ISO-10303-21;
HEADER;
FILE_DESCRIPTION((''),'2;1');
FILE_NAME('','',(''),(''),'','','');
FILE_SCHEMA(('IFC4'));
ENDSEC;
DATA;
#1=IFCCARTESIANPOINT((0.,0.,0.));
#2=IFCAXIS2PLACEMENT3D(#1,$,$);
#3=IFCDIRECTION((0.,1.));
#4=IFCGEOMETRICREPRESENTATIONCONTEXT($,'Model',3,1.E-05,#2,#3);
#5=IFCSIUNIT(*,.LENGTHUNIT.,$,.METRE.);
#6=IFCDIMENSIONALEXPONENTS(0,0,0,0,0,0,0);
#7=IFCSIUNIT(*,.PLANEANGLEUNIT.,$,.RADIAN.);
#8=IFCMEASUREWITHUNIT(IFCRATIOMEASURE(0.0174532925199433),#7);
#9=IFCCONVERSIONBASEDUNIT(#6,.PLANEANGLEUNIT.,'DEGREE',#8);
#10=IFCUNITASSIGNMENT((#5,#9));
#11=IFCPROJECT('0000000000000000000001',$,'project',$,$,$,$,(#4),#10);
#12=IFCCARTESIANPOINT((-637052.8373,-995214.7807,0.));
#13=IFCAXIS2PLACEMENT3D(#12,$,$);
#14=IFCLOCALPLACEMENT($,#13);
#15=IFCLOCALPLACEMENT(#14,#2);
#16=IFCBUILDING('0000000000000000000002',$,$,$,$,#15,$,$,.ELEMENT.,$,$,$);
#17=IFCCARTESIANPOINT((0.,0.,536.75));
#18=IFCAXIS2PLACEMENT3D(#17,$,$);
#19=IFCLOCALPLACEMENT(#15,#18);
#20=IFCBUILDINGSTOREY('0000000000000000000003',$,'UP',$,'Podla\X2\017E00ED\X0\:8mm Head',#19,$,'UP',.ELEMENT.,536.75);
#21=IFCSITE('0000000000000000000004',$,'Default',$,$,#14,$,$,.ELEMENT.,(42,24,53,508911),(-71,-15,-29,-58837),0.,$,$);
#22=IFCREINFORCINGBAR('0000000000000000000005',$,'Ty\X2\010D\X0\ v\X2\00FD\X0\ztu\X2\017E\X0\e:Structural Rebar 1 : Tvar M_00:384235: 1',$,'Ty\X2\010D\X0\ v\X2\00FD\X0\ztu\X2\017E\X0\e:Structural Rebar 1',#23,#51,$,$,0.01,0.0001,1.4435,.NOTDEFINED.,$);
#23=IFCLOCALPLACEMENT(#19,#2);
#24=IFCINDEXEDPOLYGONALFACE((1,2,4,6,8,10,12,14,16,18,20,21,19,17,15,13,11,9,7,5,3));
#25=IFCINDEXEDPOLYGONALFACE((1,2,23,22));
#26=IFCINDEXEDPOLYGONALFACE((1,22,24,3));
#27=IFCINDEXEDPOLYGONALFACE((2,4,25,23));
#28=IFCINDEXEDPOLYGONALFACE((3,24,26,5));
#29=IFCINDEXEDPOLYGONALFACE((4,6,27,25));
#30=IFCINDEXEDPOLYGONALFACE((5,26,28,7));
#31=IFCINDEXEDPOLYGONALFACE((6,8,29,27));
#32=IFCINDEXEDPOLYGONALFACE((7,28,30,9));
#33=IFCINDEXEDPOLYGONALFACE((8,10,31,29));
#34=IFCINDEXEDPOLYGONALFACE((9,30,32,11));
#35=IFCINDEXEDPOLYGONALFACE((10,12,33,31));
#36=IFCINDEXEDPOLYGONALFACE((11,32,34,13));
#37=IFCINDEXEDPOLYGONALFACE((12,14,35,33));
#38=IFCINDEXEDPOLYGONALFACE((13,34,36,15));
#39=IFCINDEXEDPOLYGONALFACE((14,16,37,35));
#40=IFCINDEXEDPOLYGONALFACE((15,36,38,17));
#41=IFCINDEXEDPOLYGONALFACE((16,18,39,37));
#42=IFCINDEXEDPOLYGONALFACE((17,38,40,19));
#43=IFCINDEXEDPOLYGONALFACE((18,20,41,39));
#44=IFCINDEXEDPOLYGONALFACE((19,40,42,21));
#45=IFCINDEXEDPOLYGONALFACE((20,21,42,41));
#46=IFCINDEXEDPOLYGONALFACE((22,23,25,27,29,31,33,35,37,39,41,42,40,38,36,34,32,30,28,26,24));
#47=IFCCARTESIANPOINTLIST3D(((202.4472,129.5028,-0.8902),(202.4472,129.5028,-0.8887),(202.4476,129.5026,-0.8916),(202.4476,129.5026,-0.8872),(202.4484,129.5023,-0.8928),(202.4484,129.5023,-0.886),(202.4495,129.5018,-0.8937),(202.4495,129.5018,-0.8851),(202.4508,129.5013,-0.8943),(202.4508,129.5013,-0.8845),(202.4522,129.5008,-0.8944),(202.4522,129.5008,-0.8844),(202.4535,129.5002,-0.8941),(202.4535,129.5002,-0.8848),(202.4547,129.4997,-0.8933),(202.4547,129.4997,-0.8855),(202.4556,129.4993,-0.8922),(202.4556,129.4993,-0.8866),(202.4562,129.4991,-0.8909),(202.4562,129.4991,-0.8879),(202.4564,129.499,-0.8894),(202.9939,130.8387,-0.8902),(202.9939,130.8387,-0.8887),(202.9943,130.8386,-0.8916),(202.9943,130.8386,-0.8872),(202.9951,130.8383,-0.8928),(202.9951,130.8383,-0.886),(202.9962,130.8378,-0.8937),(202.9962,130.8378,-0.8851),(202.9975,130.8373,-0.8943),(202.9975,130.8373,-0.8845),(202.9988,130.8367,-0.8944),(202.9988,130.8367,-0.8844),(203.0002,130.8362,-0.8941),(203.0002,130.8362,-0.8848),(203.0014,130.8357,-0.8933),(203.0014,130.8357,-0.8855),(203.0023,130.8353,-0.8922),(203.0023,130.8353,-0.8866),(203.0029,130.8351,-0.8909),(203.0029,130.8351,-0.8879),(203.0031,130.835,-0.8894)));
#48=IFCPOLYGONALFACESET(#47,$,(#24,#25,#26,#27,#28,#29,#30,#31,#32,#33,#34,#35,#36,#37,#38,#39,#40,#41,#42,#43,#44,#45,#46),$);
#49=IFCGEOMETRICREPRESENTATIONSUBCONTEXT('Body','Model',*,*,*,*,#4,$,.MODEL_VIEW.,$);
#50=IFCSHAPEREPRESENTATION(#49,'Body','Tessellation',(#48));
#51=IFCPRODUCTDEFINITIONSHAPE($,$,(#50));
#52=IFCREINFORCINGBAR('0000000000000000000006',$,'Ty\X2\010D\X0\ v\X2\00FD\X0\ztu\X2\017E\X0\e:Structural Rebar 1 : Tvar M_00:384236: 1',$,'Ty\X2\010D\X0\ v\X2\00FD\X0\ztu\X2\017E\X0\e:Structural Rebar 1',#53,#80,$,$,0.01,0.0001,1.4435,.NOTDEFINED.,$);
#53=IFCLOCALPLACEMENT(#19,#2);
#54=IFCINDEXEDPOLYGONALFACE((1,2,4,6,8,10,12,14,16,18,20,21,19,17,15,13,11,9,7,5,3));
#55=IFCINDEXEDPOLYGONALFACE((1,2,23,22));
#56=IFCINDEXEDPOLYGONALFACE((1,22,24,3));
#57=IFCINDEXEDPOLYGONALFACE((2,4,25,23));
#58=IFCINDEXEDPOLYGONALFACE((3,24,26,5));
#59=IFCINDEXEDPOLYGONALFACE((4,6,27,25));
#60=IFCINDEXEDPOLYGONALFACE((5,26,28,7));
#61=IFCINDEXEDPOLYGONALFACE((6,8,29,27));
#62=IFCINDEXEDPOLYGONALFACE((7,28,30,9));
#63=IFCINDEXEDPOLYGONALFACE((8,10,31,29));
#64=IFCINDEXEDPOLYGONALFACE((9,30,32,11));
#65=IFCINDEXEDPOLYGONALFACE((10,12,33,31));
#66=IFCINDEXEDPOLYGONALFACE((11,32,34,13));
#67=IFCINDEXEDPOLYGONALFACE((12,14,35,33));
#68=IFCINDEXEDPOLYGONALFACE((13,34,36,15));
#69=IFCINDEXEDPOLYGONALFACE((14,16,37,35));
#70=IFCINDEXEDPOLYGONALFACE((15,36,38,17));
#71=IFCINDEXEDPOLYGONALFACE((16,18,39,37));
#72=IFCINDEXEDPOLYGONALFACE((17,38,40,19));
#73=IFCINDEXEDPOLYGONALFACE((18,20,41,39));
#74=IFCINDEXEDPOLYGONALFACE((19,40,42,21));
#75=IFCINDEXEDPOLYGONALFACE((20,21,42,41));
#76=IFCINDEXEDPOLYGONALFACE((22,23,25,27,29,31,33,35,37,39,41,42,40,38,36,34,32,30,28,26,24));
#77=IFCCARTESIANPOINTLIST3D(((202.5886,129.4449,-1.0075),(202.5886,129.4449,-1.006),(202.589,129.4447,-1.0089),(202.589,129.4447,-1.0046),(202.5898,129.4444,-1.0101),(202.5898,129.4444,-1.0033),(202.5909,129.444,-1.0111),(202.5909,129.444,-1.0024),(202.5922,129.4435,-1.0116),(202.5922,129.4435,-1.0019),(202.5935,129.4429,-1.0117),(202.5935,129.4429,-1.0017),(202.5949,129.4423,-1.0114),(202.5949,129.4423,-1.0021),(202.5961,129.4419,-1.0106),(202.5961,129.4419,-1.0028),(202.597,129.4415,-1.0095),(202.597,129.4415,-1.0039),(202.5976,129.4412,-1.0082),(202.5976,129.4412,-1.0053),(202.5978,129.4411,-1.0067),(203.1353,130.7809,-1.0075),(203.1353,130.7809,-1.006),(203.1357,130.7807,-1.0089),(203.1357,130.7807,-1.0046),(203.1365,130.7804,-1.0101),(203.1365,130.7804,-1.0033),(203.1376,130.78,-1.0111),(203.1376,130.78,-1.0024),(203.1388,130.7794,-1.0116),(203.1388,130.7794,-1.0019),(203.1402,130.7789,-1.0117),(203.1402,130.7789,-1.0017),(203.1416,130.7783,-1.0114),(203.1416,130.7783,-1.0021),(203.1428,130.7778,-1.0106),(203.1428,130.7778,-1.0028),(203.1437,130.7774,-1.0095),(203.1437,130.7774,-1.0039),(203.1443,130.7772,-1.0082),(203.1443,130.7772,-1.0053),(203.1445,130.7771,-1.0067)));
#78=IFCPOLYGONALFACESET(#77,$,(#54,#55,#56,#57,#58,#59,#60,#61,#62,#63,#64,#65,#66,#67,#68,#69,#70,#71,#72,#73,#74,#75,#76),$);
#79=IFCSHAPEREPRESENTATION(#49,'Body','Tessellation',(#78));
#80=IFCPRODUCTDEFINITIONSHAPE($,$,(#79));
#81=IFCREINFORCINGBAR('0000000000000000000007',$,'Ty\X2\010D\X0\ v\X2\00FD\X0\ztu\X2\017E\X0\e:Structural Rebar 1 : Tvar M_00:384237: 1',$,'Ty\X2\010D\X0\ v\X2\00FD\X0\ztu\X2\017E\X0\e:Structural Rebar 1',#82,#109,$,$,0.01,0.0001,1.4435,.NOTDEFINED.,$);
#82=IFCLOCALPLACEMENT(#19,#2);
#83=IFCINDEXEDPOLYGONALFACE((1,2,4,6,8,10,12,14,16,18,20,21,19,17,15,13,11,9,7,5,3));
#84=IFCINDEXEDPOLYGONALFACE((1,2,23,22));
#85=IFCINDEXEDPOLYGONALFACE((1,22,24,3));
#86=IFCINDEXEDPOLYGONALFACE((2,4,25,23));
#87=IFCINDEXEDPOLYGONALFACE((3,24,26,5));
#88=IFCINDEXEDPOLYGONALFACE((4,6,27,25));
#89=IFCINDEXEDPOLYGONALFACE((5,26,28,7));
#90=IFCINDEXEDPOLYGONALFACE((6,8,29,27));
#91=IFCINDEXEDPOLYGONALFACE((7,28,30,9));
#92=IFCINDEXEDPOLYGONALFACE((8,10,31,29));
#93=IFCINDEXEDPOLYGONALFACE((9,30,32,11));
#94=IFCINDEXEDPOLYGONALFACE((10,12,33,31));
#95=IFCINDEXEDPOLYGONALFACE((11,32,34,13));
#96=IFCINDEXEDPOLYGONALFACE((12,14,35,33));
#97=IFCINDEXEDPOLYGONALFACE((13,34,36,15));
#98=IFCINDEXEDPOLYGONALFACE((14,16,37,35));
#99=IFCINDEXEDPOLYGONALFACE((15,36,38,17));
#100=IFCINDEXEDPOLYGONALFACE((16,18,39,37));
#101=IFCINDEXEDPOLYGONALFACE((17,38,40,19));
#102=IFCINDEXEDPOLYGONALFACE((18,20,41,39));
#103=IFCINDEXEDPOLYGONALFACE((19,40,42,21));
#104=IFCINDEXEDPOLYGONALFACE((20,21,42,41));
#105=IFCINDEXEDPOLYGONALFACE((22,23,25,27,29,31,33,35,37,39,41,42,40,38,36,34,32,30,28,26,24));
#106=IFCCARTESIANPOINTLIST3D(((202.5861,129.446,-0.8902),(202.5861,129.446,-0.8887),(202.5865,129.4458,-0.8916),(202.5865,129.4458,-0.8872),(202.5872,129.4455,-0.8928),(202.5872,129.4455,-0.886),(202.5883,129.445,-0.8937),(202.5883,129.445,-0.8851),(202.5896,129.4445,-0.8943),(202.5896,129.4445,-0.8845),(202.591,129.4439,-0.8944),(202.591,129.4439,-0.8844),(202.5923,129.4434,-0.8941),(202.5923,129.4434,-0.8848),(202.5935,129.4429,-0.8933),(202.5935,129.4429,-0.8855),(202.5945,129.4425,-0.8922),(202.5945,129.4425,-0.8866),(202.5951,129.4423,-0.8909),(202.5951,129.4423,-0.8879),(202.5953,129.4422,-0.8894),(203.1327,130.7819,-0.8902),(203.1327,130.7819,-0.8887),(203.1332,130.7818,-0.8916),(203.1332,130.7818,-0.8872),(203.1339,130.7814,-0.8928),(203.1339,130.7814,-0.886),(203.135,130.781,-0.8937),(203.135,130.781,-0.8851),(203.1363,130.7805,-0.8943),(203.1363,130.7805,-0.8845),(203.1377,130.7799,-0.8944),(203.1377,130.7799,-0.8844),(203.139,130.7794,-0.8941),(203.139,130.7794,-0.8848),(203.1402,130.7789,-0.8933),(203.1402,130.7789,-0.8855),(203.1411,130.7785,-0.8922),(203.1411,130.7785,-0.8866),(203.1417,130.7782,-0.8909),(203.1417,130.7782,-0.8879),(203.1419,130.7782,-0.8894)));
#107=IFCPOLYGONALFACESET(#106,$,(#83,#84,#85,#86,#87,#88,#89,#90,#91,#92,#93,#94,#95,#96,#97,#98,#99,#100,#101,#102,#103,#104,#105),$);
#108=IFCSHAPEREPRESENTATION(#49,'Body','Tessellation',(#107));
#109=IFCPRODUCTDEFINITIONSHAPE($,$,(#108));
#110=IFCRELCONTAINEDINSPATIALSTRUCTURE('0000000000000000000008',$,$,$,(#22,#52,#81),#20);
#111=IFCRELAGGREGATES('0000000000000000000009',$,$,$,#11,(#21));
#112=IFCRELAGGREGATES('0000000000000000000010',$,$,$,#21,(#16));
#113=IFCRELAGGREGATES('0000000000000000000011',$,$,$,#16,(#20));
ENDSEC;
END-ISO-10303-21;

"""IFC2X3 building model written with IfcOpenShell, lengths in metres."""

from ifc_helpers import new_model, entity, si_unit, converted_unit, direction, frame, origin, place, context, subcontext, project, spatial, element, save


model = new_model("IFC2X3")

# Units and contexts
model_context = context("Model", 3, precision=1e-05, world=origin(), true_north=direction((0.0, 1.0)))
body_context = subcontext(model_context, "Body", "Model", "MODEL_VIEW")
ifc_project = project(units=[si_unit("LENGTHUNIT", "METRE"), converted_unit("PLANEANGLEUNIT", "DEGREE", entity("IfcRatioMeasure", 0.0174532925199433), si_unit("PLANEANGLEUNIT", "RADIAN"), dimensions=[0, 0, 0, 0, 0, 0, 0])], contexts=[model_context])

# Site, building, storey
site_placement = place(None, frame((-637052.8373, -995214.7807, 0.0)))
site = spatial("IfcSite", under=ifc_project, at=site_placement, Name="Default", CompositionType="ELEMENT", RefLatitude=(42, 24, 53, 508911), RefLongitude=(-71, -15, -29, -58837), RefElevation=0.0)
building_placement = place(site_placement, origin())
building = spatial("IfcBuilding", under=site, at=building_placement, CompositionType="ELEMENT")
storey_placement = place(building_placement, frame((0.0, 0.0, 536.75)))
storey = spatial("IfcBuildingStorey", under=building, at=storey_placement, Name="UP", ObjectType="Podlaží:8mm Head", LongName="UP", CompositionType="ELEMENT", Elevation=536.75)

# Reinforcing bars
reinforcing_bar_1_placement = place(storey_placement, origin())
element("IfcReinforcingBar", 1, at=reinforcing_bar_1_placement, inside=storey, Name="Tyč výztuže:Structural Rebar 1 : Tvar M_00:384235: 1", ObjectType="Tyč výztuže:Structural Rebar 1", BarLength=1.4435, BarRole="NOTDEFINED", CrossSectionArea=0.0001, NominalDiameter=0.01, context=body_context, shape_type="AdvancedSweptSolid", body=[
    entity("IfcSweptDiskSolid", entity("IfcCompositeCurve", [entity("IfcCompositeCurveSegment", "CONTINUOUS", True, entity("IfcPolyline", [entity("IfcCartesianPoint", [-202.9985, -130.8369, 0.8894]), entity("IfcCartesianPoint", [-202.4518, -129.5009, 0.8894])]))], False), 0.005, None, 0.0, 1.0),
])
reinforcing_bar_2_placement = place(storey_placement, origin())
element("IfcReinforcingBar", 2, at=reinforcing_bar_2_placement, inside=storey, Name="Tyč výztuže:Structural Rebar 1 : Tvar M_00:384236: 1", ObjectType="Tyč výztuže:Structural Rebar 1", BarLength=1.4435, BarRole="NOTDEFINED", CrossSectionArea=0.0001, NominalDiameter=0.01, context=body_context, shape_type="AdvancedSweptSolid", body=[
    entity("IfcSweptDiskSolid", entity("IfcCompositeCurve", [entity("IfcCompositeCurveSegment", "CONTINUOUS", True, entity("IfcPolyline", [entity("IfcCartesianPoint", [-203.1399, -130.779, 1.0067]), entity("IfcCartesianPoint", [-202.5932, -129.443, 1.0067])]))], False), 0.005, None, 0.0, 1.0),
])
reinforcing_bar_3_placement = place(storey_placement, origin())
element("IfcReinforcingBar", 3, at=reinforcing_bar_3_placement, inside=storey, Name="Tyč výztuže:Structural Rebar 1 : Tvar M_00:384237: 1", ObjectType="Tyč výztuže:Structural Rebar 1", BarLength=1.4435, BarRole="NOTDEFINED", CrossSectionArea=0.0001, NominalDiameter=0.01, context=body_context, shape_type="AdvancedSweptSolid", body=[
    entity("IfcSweptDiskSolid", entity("IfcCompositeCurve", [entity("IfcCompositeCurveSegment", "CONTINUOUS", True, entity("IfcPolyline", [entity("IfcCartesianPoint", [-203.1373, -130.7801, 0.8894]), entity("IfcCartesianPoint", [-202.5906, -129.4441, 0.8894])]))], False), 0.005, None, 0.0, 1.0),
])

save(model, "model.ifc")
